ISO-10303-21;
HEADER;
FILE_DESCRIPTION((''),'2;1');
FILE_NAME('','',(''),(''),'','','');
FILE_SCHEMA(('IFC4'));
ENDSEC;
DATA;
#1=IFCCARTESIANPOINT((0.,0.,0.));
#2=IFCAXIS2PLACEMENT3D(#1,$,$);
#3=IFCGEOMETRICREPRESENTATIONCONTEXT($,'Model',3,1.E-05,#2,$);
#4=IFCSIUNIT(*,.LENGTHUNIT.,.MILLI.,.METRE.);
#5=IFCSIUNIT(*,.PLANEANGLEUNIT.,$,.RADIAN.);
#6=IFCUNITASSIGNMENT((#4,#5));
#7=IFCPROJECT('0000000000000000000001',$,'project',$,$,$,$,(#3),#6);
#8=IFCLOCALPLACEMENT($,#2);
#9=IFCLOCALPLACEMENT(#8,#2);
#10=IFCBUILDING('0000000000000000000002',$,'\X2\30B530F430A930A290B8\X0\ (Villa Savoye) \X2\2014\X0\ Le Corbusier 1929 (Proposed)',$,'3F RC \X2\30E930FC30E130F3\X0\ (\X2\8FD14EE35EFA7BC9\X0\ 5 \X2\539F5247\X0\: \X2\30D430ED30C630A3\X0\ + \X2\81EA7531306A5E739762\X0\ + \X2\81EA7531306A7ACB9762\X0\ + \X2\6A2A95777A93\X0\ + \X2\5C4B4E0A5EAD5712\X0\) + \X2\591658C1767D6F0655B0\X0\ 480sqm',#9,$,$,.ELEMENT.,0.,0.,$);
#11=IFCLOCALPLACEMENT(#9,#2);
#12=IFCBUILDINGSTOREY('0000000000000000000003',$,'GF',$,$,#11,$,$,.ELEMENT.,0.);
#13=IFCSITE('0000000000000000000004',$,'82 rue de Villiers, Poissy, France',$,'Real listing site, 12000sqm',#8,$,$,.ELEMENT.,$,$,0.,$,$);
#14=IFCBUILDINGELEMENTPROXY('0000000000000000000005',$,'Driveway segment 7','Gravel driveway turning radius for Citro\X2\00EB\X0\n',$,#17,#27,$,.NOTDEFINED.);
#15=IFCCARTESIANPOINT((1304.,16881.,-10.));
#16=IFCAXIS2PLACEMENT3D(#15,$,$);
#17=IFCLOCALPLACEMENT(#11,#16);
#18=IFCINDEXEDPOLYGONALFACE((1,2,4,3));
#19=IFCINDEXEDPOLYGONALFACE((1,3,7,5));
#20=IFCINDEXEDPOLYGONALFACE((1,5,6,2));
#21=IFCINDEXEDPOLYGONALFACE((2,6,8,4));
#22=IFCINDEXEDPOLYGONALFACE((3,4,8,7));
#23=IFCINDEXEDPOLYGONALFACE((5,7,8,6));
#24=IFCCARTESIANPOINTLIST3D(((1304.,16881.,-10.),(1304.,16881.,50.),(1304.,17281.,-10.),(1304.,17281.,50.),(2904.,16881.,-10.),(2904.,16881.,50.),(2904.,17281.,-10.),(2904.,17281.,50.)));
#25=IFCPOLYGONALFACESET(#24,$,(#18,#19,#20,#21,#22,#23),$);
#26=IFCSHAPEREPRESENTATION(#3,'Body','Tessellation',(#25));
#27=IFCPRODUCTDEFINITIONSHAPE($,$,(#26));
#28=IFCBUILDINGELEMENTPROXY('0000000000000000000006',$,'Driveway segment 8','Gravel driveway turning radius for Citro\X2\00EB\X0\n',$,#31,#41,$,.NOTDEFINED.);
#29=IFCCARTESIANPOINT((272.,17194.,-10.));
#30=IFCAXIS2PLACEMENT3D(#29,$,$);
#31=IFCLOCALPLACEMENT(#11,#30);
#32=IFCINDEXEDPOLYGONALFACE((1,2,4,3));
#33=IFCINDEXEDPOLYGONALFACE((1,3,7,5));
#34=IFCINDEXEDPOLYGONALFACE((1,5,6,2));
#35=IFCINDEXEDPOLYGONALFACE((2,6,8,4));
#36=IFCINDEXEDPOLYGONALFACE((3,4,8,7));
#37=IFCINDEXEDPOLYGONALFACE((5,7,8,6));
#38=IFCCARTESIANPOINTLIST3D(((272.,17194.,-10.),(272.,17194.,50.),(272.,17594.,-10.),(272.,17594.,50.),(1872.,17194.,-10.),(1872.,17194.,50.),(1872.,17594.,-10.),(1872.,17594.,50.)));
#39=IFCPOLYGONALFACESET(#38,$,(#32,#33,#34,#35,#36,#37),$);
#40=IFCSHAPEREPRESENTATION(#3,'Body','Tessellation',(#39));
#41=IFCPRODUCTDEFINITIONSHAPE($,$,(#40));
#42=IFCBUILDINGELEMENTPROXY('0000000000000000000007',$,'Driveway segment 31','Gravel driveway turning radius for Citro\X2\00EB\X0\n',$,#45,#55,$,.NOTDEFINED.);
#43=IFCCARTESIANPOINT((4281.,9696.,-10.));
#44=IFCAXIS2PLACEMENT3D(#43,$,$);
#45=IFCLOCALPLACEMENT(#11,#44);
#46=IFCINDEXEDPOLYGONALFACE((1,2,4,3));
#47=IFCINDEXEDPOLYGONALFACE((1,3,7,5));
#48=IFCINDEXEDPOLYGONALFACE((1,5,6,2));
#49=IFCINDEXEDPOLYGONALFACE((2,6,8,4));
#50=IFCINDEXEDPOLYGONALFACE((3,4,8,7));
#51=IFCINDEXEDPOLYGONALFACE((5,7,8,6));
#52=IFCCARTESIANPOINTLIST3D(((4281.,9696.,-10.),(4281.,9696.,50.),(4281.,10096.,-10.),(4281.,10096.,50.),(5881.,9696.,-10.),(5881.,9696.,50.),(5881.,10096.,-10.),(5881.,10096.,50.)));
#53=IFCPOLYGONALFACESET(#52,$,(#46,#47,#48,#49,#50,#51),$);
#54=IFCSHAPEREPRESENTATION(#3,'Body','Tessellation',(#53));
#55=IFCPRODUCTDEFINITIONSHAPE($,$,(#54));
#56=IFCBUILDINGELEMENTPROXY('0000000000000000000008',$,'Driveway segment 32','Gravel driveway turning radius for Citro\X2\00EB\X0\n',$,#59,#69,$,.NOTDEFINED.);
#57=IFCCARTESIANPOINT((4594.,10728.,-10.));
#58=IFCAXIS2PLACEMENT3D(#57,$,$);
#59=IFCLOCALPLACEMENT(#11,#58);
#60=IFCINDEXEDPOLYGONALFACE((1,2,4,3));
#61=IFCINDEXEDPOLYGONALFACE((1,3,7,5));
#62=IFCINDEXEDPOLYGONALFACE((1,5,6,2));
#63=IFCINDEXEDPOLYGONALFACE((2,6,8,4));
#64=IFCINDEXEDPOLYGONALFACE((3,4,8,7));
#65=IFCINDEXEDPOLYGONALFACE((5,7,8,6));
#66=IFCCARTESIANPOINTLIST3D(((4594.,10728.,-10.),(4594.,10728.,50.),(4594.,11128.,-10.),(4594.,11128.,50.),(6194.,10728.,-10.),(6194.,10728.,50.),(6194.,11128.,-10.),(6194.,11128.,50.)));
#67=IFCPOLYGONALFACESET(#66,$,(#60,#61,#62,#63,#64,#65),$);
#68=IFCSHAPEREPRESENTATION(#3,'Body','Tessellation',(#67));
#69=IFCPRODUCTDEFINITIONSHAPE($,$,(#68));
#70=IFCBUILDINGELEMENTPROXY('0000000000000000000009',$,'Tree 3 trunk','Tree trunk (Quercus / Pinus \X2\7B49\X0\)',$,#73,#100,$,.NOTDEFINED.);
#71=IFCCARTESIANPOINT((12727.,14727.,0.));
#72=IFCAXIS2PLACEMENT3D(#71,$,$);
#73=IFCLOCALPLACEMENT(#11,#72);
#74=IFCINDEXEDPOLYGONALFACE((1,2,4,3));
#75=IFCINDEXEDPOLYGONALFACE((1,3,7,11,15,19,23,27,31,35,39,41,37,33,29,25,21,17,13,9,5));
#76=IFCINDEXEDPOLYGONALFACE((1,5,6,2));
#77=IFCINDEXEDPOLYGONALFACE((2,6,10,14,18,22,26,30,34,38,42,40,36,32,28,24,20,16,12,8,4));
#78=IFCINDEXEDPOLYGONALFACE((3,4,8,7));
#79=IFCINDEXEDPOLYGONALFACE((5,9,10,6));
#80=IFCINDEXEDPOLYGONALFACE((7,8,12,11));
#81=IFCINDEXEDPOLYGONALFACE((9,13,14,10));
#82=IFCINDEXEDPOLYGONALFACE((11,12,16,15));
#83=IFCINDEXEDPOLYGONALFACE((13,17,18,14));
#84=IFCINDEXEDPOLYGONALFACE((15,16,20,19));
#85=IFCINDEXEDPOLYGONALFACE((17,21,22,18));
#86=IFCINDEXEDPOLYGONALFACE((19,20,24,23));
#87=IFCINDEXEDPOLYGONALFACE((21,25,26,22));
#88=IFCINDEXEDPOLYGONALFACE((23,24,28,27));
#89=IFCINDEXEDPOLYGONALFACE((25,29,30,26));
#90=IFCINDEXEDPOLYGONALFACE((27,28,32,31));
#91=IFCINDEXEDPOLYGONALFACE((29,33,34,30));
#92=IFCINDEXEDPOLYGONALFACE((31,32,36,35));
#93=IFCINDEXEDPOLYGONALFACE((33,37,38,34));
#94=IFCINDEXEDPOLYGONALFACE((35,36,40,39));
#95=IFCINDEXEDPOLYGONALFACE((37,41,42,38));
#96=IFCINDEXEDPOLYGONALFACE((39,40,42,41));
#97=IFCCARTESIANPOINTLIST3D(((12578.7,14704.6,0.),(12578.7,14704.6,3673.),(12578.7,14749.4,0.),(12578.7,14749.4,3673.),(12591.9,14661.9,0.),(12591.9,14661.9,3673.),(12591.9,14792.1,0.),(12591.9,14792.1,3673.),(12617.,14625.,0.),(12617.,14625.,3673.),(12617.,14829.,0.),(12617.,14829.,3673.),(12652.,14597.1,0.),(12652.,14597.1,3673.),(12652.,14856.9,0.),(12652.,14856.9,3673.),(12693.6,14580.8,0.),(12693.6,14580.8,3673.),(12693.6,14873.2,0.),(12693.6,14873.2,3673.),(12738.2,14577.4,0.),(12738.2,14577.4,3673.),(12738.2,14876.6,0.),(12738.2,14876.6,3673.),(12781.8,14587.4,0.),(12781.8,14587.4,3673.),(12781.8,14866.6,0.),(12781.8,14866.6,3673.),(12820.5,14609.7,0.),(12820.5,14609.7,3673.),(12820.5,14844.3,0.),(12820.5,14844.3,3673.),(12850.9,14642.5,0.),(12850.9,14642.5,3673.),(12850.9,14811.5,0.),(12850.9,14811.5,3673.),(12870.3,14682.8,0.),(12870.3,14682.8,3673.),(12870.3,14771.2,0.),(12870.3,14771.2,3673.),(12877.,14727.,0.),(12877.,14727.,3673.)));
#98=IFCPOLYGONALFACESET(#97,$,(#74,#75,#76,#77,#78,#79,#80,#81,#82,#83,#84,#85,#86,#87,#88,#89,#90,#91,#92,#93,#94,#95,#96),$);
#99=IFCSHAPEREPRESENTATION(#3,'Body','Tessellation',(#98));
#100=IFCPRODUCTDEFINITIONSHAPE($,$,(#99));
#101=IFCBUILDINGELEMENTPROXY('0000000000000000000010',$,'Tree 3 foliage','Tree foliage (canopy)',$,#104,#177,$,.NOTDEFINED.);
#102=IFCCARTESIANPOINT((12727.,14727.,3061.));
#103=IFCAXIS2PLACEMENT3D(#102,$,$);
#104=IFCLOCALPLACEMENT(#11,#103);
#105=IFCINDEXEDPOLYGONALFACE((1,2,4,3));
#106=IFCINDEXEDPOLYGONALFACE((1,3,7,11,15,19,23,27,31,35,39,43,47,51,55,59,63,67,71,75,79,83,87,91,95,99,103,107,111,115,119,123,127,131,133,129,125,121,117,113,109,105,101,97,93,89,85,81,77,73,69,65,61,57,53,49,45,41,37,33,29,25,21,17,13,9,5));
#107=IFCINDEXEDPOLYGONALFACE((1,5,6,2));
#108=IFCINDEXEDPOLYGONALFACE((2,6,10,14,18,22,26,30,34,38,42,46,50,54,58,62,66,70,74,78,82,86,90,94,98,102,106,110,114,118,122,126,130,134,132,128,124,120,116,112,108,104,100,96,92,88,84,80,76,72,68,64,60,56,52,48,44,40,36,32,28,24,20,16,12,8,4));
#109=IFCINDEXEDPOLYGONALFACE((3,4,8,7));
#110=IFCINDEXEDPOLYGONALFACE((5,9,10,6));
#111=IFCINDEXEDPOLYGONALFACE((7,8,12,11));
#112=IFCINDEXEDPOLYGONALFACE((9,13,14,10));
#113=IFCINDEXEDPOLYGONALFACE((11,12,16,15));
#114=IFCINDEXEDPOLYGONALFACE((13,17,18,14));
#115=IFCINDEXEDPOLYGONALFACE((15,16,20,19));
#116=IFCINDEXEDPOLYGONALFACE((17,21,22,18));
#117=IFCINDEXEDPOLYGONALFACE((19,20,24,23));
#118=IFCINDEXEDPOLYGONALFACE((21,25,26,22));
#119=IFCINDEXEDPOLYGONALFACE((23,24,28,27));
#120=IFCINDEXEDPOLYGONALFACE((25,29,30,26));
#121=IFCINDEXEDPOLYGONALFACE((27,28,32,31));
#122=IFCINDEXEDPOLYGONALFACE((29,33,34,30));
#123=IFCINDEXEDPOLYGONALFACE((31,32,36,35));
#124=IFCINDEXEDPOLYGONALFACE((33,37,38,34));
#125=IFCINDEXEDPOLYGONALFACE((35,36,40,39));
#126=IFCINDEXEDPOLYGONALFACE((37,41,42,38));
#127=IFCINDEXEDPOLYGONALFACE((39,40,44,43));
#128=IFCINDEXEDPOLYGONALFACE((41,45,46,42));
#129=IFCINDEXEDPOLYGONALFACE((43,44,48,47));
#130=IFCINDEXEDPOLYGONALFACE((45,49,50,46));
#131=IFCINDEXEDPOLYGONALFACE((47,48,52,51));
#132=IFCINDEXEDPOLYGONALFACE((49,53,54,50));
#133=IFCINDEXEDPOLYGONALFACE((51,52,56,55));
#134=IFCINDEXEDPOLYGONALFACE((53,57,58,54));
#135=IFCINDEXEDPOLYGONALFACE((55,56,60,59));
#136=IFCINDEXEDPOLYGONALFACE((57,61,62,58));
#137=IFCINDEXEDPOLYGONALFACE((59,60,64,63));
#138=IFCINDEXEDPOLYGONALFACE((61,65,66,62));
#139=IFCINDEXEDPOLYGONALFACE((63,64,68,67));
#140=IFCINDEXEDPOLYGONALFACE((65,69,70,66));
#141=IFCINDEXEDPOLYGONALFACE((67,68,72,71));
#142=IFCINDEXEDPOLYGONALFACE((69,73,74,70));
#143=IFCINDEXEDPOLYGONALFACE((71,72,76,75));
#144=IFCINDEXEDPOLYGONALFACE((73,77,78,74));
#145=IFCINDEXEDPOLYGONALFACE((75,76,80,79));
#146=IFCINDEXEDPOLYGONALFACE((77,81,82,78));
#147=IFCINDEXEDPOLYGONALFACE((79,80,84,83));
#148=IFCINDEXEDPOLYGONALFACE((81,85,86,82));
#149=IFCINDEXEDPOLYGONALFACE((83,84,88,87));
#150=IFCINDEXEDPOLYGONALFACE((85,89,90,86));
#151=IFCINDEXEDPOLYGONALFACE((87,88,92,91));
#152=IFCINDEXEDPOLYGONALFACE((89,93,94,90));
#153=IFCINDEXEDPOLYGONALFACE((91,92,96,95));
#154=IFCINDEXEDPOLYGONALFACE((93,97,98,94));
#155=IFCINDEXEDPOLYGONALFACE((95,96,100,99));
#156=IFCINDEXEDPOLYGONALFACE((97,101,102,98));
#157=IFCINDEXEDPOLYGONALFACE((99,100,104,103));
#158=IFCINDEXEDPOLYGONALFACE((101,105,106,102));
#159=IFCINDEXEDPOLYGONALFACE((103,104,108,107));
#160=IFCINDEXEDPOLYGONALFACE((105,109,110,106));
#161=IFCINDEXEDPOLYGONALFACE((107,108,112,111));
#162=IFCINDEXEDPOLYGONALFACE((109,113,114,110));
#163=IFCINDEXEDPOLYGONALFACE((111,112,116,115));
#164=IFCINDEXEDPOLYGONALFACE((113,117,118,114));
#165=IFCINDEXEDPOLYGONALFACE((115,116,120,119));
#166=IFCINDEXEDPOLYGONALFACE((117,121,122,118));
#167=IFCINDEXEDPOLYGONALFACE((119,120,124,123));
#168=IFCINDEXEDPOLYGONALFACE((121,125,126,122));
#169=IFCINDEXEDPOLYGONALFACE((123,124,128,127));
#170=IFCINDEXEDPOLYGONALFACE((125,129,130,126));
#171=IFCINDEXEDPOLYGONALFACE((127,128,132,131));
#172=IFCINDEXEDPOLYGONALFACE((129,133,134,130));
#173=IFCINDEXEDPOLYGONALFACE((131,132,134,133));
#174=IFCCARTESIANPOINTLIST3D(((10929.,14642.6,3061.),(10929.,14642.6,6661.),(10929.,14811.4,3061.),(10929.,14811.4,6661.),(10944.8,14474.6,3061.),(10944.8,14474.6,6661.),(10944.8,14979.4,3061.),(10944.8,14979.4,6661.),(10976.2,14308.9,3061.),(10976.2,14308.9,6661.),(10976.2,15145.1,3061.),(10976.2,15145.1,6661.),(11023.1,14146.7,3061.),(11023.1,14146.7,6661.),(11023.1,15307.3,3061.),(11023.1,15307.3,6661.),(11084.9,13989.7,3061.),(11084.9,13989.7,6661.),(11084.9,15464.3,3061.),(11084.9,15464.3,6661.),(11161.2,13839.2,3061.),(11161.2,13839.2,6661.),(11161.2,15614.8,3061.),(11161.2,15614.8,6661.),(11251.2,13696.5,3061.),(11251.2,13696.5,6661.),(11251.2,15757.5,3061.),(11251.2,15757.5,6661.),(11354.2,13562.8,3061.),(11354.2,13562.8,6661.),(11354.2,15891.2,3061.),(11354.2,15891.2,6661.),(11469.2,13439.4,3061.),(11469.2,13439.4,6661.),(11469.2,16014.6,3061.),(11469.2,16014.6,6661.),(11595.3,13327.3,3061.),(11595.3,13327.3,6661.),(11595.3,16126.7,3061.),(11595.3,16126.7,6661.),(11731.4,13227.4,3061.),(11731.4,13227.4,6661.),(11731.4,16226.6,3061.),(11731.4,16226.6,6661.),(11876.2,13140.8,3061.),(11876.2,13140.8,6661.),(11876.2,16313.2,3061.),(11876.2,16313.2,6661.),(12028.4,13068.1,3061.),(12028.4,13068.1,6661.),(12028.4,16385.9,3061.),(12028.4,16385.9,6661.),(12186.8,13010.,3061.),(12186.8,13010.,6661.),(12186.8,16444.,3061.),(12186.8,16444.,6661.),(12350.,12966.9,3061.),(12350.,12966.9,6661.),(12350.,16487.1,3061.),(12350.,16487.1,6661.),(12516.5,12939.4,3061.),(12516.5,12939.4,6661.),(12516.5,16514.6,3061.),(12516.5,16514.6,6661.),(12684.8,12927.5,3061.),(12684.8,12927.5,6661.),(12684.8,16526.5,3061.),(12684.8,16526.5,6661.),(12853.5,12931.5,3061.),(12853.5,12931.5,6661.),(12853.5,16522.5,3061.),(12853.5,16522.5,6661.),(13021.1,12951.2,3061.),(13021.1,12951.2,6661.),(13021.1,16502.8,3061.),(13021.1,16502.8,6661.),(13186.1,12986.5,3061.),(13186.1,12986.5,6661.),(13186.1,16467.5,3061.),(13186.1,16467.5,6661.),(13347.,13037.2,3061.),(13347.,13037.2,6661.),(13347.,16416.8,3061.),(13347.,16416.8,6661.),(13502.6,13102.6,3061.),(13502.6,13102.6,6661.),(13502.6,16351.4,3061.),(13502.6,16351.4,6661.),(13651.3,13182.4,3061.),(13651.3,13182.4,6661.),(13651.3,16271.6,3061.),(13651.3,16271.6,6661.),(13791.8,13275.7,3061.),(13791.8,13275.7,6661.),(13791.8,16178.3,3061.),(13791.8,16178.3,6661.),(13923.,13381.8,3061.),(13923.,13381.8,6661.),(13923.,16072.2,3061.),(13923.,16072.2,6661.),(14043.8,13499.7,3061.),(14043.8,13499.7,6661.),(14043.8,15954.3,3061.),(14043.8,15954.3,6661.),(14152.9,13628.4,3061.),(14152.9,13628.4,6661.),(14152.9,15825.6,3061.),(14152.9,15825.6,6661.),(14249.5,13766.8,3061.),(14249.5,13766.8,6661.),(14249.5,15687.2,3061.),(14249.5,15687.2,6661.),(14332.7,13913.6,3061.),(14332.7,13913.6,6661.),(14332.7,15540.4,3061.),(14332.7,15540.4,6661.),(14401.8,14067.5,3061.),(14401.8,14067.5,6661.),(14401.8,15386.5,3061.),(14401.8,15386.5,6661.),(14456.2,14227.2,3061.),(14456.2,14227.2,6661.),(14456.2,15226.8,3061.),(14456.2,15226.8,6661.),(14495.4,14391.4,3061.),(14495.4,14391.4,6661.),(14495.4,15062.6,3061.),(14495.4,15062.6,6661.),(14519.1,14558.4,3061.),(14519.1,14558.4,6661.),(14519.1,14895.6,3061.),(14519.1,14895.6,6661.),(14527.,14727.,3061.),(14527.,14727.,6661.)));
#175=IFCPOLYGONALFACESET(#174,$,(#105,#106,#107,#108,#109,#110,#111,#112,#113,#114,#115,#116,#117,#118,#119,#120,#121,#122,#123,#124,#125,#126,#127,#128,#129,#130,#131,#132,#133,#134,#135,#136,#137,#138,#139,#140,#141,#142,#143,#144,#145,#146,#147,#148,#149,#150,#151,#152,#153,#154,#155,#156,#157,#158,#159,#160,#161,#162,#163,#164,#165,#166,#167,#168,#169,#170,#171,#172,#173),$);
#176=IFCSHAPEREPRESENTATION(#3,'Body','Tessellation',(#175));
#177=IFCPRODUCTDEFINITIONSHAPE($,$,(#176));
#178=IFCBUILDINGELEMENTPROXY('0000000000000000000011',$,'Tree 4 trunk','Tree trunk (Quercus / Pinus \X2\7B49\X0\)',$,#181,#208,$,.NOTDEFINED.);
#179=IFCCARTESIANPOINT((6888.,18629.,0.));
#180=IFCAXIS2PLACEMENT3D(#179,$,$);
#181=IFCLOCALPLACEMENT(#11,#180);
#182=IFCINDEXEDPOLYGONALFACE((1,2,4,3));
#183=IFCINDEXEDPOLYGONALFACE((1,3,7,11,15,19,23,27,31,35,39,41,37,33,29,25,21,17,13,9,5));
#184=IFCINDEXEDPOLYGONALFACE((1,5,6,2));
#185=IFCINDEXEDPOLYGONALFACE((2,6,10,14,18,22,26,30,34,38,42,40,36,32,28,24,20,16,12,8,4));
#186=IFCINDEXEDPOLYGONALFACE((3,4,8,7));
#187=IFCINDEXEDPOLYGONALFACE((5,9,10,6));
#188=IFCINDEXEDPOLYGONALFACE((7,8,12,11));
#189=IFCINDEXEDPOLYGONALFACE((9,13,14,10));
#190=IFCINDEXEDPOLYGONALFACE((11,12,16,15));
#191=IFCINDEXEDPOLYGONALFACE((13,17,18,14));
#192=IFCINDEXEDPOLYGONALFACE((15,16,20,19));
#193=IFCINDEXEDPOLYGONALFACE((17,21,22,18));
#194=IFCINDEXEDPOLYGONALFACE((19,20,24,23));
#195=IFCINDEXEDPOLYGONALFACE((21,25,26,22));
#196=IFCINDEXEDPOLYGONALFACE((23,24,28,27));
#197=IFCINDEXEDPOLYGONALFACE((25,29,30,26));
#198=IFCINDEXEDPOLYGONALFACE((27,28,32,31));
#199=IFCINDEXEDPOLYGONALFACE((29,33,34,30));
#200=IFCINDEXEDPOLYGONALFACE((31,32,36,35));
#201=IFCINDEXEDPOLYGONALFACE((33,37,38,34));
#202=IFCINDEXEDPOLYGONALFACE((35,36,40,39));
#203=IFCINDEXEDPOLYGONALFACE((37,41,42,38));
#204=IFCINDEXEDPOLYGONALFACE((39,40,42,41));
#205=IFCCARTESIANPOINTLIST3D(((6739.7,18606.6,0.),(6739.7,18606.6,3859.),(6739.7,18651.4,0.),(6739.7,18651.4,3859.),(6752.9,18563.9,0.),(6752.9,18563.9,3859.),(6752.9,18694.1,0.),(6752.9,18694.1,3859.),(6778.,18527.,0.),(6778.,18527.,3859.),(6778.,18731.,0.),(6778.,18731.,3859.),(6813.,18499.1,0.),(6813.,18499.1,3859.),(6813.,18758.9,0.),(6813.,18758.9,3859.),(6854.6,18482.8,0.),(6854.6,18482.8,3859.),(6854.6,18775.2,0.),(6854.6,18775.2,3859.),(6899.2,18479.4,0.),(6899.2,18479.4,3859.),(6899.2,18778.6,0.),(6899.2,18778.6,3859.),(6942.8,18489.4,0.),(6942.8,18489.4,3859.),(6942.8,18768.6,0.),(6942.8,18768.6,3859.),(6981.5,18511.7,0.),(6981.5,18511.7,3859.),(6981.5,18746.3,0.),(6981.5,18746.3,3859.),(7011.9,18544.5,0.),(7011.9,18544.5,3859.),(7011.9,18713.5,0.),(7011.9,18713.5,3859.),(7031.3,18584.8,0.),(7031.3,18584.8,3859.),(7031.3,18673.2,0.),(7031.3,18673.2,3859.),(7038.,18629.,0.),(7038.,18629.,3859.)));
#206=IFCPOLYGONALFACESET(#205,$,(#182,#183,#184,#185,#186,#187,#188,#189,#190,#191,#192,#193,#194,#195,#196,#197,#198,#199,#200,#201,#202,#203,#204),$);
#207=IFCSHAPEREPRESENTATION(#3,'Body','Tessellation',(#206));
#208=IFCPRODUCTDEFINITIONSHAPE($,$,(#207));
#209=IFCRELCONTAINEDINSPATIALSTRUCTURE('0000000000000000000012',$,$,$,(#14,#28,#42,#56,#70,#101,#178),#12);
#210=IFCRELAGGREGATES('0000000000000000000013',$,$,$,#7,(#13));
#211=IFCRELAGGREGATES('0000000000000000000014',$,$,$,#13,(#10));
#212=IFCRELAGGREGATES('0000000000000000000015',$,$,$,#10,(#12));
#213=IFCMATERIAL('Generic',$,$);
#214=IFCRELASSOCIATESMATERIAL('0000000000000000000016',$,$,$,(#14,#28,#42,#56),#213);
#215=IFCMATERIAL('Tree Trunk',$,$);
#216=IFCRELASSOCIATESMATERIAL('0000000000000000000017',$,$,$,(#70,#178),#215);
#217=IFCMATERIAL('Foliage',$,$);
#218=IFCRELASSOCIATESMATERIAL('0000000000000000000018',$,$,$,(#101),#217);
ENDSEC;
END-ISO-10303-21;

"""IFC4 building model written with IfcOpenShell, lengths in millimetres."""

from ifc_helpers import new_model, si_unit, frame, frame_2d, origin, origin_2d, place, context, project, spatial, rectangle, circle, extrude, material, element, save


model = new_model("IFC4")

# Units and contexts
model_context = context("Model", 3, precision=1e-05, world=origin())
ifc_project = project(units=[si_unit("LENGTHUNIT", "METRE", prefix="MILLI"), si_unit("PLANEANGLEUNIT", "RADIAN")], contexts=[model_context])

# Site, building, storey
site_placement = place(None, origin())
site = spatial("IfcSite", under=ifc_project, at=site_placement, Name="82 rue de Villiers, Poissy, France", ObjectType="Real listing site, 12000sqm", CompositionType="ELEMENT", RefElevation=0.0)
building_placement = place(site_placement, origin())
building = spatial("IfcBuilding", under=site, at=building_placement, Name="サヴォア邸 (Villa Savoye) — Le Corbusier 1929 (Proposed)", ObjectType="3F RC ラーメン (近代建築 5 原則: ピロティ + 自由な平面 + 自由な立面 + 横長窓 + 屋上庭園) + 外壁白漆喰 480sqm", CompositionType="ELEMENT", ElevationOfRefHeight=0.0, ElevationOfTerrain=0.0)
storey_placement = place(building_placement, origin())
storey = spatial("IfcBuildingStorey", under=building, at=storey_placement, Name="GF", CompositionType="ELEMENT", Elevation=0.0)

# Shared definitions
ifc_material_1 = material(Name="Generic")

# Building element proxies
proxy_1_placement = place(storey_placement, frame((1304.0, 16881.0, -10.0)))
element("IfcBuildingElementProxy", 1, at=proxy_1_placement, inside=storey, material=ifc_material_1, Name="Driveway segment 7", Description="Gravel driveway turning radius for Citroën", PredefinedType="NOTDEFINED", context=model_context, shape_type="SweptSolid", body=[
    extrude(rectangle(XDim=1600.0, YDim=400.0, at=frame_2d((800.0, 200.0))), frame((1304.0, 16881.0, -10.0)), (0.0, 0.0, 1.0), 60.0),
])
proxy_2_placement = place(storey_placement, frame((272.0, 17194.0, -10.0)))
element("IfcBuildingElementProxy", 2, at=proxy_2_placement, inside=storey, material=ifc_material_1, Name="Driveway segment 8", Description="Gravel driveway turning radius for Citroën", PredefinedType="NOTDEFINED", context=model_context, shape_type="SweptSolid", body=[
    extrude(rectangle(XDim=1600.0, YDim=400.0, at=frame_2d((800.0, 200.0))), frame((272.0, 17194.0, -10.0)), (0.0, 0.0, 1.0), 60.0),
])
proxy_3_placement = place(storey_placement, frame((4281.0, 9696.0, -10.0)))
element("IfcBuildingElementProxy", 3, at=proxy_3_placement, inside=storey, material=ifc_material_1, Name="Driveway segment 31", Description="Gravel driveway turning radius for Citroën", PredefinedType="NOTDEFINED", context=model_context, shape_type="SweptSolid", body=[
    extrude(rectangle(XDim=1600.0, YDim=400.0, at=frame_2d((800.0, 200.0))), frame((4281.0, 9696.0, -10.0)), (0.0, 0.0, 1.0), 60.0),
])
proxy_4_placement = place(storey_placement, frame((4594.0, 10728.0, -10.0)))
element("IfcBuildingElementProxy", 4, at=proxy_4_placement, inside=storey, material=ifc_material_1, Name="Driveway segment 32", Description="Gravel driveway turning radius for Citroën", PredefinedType="NOTDEFINED", context=model_context, shape_type="SweptSolid", body=[
    extrude(rectangle(XDim=1600.0, YDim=400.0, at=frame_2d((800.0, 200.0))), frame((4594.0, 10728.0, -10.0)), (0.0, 0.0, 1.0), 60.0),
])
ifc_material_2 = material(Name="Tree Trunk")
proxy_5_placement = place(storey_placement, frame((12727.0, 14727.0, 0.0)))
element("IfcBuildingElementProxy", 5, at=proxy_5_placement, inside=storey, material=ifc_material_2, Name="Tree 3 trunk", Description="Tree trunk (Quercus / Pinus 等)", PredefinedType="NOTDEFINED", context=model_context, shape_type="SweptSolid", body=[
    extrude(circle(Radius=150.0, at=origin_2d()), frame((12727.0, 14727.0, 0.0)), (0.0, 0.0, 1.0), 3673.0),
])
ifc_material_3 = material(Name="Foliage")
proxy_6_placement = place(storey_placement, frame((12727.0, 14727.0, 3061.0)))
element("IfcBuildingElementProxy", 6, at=proxy_6_placement, inside=storey, material=ifc_material_3, Name="Tree 3 foliage", Description="Tree foliage (canopy)", PredefinedType="NOTDEFINED", context=model_context, shape_type="SweptSolid", body=[
    extrude(circle(Radius=1800.0, at=origin_2d()), frame((12727.0, 14727.0, 3061.0)), (0.0, 0.0, 1.0), 3600.0),
])
proxy_7_placement = place(storey_placement, frame((6888.0, 18629.0, 0.0)))
element("IfcBuildingElementProxy", 7, at=proxy_7_placement, inside=storey, material=ifc_material_2, Name="Tree 4 trunk", Description="Tree trunk (Quercus / Pinus 等)", PredefinedType="NOTDEFINED", context=model_context, shape_type="SweptSolid", body=[
    extrude(circle(Radius=150.0, at=origin_2d()), frame((6888.0, 18629.0, 0.0)), (0.0, 0.0, 1.0), 3859.0),
])

save(model, "model.ifc")
